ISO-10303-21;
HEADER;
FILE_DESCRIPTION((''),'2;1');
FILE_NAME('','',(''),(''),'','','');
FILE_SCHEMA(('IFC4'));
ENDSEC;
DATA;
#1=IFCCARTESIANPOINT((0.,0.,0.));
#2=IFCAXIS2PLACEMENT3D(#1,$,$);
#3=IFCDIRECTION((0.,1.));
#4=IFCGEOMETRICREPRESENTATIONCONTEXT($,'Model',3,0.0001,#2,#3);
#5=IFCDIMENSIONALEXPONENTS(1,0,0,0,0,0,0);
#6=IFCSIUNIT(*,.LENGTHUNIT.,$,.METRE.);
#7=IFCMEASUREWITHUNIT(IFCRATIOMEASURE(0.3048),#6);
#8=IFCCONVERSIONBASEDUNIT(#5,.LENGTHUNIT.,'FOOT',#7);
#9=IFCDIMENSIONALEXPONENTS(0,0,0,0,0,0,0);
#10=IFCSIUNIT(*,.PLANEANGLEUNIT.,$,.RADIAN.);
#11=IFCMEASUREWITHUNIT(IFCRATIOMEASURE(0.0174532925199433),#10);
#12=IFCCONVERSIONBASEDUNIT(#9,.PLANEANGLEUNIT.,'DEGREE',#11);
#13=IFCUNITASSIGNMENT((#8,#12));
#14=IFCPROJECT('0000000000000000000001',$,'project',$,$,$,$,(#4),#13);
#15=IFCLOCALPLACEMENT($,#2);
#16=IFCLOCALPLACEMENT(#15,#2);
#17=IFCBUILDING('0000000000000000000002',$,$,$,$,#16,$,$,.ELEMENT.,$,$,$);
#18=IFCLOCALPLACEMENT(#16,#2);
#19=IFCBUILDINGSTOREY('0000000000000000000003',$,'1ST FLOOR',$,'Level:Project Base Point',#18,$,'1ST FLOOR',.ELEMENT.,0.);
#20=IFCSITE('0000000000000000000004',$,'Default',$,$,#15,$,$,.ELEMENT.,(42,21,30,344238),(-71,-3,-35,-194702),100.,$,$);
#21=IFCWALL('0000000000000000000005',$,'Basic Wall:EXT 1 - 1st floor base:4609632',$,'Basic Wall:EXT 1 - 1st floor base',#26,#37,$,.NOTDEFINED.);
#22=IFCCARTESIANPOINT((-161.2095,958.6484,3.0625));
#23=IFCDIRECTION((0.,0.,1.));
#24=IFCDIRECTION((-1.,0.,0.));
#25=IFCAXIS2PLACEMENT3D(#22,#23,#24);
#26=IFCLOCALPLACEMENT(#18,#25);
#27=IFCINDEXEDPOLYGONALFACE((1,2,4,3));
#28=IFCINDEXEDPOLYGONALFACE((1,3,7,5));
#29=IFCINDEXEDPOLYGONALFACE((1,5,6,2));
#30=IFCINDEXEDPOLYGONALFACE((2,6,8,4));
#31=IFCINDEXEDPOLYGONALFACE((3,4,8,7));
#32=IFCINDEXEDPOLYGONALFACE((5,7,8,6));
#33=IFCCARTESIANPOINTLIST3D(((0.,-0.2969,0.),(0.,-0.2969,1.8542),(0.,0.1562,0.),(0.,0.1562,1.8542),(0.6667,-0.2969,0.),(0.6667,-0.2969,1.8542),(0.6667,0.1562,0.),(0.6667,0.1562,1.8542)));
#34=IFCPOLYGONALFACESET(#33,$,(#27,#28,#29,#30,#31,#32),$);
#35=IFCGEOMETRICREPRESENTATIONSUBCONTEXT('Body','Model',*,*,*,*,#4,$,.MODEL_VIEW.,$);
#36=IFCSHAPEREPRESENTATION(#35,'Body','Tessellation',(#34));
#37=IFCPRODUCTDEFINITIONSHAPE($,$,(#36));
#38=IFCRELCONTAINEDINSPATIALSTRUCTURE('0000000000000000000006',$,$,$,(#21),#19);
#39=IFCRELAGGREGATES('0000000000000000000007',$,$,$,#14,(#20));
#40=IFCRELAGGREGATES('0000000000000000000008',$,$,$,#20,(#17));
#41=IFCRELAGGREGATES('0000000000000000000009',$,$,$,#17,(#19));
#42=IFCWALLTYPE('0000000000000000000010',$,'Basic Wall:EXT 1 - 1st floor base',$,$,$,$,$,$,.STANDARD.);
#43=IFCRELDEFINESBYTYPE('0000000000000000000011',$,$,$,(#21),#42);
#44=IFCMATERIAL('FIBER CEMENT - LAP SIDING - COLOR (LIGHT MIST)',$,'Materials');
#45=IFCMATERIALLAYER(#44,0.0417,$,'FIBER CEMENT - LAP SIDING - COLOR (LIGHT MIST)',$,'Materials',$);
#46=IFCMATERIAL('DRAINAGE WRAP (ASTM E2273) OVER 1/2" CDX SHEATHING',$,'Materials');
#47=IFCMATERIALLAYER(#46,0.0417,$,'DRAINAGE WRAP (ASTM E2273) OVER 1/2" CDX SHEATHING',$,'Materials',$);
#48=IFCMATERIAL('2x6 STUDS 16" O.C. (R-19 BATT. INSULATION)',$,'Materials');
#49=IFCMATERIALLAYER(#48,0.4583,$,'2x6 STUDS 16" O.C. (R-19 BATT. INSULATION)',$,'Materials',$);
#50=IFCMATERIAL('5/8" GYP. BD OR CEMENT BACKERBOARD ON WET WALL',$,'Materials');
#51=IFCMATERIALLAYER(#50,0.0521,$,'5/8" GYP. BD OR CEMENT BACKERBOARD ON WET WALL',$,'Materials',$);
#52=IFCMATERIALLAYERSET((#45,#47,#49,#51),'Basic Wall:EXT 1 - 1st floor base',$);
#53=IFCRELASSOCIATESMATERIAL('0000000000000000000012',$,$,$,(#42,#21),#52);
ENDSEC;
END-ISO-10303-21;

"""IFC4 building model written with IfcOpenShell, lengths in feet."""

from ifc_helpers import new_model, entity, si_unit, converted_unit, direction, frame, frame_2d, origin, place, context, subcontext, project, spatial, rectangle, extrude, material, layer, layer_set, layer_usage, type_object, element, save


model = new_model("IFC4")

# Units and contexts
model_context = context("Model", 3, precision=0.0001, world=origin(), true_north=direction((0.0, 1.0)))
body_context = subcontext(model_context, "Body", "Model", "MODEL_VIEW")
ifc_project = project(units=[converted_unit("LENGTHUNIT", "FOOT", entity("IfcRatioMeasure", 0.3048), si_unit("LENGTHUNIT", "METRE"), dimensions=[1, 0, 0, 0, 0, 0, 0]), converted_unit("PLANEANGLEUNIT", "DEGREE", entity("IfcRatioMeasure", 0.0174532925199433), si_unit("PLANEANGLEUNIT", "RADIAN"), dimensions=[0, 0, 0, 0, 0, 0, 0])], contexts=[model_context])

# Site, building, storey
site_placement = place(None, origin())
site = spatial("IfcSite", under=ifc_project, at=site_placement, Name="Default", CompositionType="ELEMENT", RefLatitude=(42, 21, 30, 344238), RefLongitude=(-71, -3, -35, -194702), RefElevation=100.0)
building_placement = place(site_placement, origin())
building = spatial("IfcBuilding", under=site, at=building_placement, CompositionType="ELEMENT")
storey_placement = place(building_placement, origin())
storey = spatial("IfcBuildingStorey", under=building, at=storey_placement, Name="1ST FLOOR", ObjectType="Level:Project Base Point", LongName="1ST FLOOR", CompositionType="ELEMENT", Elevation=0.0)

# Shared definitions
ifc_material_1 = material(Name="FIBER CEMENT - LAP SIDING - COLOR (LIGHT MIST)", Category="Materials")
ifc_layer_1 = layer(ifc_material_1, 0.0417, Name="FIBER CEMENT - LAP SIDING - COLOR (LIGHT MIST)", Category="Materials")
ifc_material_2 = material(Name="DRAINAGE WRAP (ASTM E2273) OVER 1/2\" CDX SHEATHING", Category="Materials")
ifc_layer_2 = layer(ifc_material_2, 0.0417, Name="DRAINAGE WRAP (ASTM E2273) OVER 1/2\" CDX SHEATHING", Category="Materials")
ifc_material_3 = material(Name="2x6 STUDS 16\" O.C. (R-19 BATT. INSULATION)", Category="Materials")
ifc_layer_3 = layer(ifc_material_3, 0.4583, Name="2x6 STUDS 16\" O.C. (R-19 BATT. INSULATION)", Category="Materials")
ifc_material_4 = material(Name="5/8\" GYP. BD OR CEMENT BACKERBOARD ON WET WALL", Category="Materials")
ifc_layer_4 = layer(ifc_material_4, 0.0521, Name="5/8\" GYP. BD OR CEMENT BACKERBOARD ON WET WALL", Category="Materials")
ifc_layer_set_1 = layer_set([ifc_layer_1, ifc_layer_2, ifc_layer_3, ifc_layer_4], Name="Basic Wall:EXT 1 - 1st floor base")
wall_type_1 = type_object("IfcWallType", Name="Basic Wall:EXT 1 - 1st floor base", PredefinedType="STANDARD", material=ifc_layer_set_1)

# Wall
ifc_layer_usage_1 = layer_usage(ifc_layer_set_1, "AXIS2", "POSITIVE", -0.2969)
wall_1_placement = place(storey_placement, frame((-161.2095, 958.6484, 3.0625), z_axis=(0.0, 0.0, 1.0), x_axis=(-1.0, 0.0, 0.0)))
element("IfcWall", 1, at=wall_1_placement, inside=storey, type_object=wall_type_1, material=ifc_layer_usage_1, Name="Basic Wall:EXT 1 - 1st floor base:4609632", ObjectType="Basic Wall:EXT 1 - 1st floor base", PredefinedType="NOTDEFINED", context=body_context, shape_type="SweptSolid", body=[
    extrude(rectangle(XDim=0.4531, YDim=0.6667, at=frame_2d((0.0, 0.0), x_axis=(1.0, 0.0))), frame((0.3333, -0.0703, 0.0), z_axis=(0.0, 0.0, 1.0), x_axis=(0.0, -1.0, 0.0)), (0.0, 0.0, 1.0), 1.8542),
])

save(model, "model.ifc")
